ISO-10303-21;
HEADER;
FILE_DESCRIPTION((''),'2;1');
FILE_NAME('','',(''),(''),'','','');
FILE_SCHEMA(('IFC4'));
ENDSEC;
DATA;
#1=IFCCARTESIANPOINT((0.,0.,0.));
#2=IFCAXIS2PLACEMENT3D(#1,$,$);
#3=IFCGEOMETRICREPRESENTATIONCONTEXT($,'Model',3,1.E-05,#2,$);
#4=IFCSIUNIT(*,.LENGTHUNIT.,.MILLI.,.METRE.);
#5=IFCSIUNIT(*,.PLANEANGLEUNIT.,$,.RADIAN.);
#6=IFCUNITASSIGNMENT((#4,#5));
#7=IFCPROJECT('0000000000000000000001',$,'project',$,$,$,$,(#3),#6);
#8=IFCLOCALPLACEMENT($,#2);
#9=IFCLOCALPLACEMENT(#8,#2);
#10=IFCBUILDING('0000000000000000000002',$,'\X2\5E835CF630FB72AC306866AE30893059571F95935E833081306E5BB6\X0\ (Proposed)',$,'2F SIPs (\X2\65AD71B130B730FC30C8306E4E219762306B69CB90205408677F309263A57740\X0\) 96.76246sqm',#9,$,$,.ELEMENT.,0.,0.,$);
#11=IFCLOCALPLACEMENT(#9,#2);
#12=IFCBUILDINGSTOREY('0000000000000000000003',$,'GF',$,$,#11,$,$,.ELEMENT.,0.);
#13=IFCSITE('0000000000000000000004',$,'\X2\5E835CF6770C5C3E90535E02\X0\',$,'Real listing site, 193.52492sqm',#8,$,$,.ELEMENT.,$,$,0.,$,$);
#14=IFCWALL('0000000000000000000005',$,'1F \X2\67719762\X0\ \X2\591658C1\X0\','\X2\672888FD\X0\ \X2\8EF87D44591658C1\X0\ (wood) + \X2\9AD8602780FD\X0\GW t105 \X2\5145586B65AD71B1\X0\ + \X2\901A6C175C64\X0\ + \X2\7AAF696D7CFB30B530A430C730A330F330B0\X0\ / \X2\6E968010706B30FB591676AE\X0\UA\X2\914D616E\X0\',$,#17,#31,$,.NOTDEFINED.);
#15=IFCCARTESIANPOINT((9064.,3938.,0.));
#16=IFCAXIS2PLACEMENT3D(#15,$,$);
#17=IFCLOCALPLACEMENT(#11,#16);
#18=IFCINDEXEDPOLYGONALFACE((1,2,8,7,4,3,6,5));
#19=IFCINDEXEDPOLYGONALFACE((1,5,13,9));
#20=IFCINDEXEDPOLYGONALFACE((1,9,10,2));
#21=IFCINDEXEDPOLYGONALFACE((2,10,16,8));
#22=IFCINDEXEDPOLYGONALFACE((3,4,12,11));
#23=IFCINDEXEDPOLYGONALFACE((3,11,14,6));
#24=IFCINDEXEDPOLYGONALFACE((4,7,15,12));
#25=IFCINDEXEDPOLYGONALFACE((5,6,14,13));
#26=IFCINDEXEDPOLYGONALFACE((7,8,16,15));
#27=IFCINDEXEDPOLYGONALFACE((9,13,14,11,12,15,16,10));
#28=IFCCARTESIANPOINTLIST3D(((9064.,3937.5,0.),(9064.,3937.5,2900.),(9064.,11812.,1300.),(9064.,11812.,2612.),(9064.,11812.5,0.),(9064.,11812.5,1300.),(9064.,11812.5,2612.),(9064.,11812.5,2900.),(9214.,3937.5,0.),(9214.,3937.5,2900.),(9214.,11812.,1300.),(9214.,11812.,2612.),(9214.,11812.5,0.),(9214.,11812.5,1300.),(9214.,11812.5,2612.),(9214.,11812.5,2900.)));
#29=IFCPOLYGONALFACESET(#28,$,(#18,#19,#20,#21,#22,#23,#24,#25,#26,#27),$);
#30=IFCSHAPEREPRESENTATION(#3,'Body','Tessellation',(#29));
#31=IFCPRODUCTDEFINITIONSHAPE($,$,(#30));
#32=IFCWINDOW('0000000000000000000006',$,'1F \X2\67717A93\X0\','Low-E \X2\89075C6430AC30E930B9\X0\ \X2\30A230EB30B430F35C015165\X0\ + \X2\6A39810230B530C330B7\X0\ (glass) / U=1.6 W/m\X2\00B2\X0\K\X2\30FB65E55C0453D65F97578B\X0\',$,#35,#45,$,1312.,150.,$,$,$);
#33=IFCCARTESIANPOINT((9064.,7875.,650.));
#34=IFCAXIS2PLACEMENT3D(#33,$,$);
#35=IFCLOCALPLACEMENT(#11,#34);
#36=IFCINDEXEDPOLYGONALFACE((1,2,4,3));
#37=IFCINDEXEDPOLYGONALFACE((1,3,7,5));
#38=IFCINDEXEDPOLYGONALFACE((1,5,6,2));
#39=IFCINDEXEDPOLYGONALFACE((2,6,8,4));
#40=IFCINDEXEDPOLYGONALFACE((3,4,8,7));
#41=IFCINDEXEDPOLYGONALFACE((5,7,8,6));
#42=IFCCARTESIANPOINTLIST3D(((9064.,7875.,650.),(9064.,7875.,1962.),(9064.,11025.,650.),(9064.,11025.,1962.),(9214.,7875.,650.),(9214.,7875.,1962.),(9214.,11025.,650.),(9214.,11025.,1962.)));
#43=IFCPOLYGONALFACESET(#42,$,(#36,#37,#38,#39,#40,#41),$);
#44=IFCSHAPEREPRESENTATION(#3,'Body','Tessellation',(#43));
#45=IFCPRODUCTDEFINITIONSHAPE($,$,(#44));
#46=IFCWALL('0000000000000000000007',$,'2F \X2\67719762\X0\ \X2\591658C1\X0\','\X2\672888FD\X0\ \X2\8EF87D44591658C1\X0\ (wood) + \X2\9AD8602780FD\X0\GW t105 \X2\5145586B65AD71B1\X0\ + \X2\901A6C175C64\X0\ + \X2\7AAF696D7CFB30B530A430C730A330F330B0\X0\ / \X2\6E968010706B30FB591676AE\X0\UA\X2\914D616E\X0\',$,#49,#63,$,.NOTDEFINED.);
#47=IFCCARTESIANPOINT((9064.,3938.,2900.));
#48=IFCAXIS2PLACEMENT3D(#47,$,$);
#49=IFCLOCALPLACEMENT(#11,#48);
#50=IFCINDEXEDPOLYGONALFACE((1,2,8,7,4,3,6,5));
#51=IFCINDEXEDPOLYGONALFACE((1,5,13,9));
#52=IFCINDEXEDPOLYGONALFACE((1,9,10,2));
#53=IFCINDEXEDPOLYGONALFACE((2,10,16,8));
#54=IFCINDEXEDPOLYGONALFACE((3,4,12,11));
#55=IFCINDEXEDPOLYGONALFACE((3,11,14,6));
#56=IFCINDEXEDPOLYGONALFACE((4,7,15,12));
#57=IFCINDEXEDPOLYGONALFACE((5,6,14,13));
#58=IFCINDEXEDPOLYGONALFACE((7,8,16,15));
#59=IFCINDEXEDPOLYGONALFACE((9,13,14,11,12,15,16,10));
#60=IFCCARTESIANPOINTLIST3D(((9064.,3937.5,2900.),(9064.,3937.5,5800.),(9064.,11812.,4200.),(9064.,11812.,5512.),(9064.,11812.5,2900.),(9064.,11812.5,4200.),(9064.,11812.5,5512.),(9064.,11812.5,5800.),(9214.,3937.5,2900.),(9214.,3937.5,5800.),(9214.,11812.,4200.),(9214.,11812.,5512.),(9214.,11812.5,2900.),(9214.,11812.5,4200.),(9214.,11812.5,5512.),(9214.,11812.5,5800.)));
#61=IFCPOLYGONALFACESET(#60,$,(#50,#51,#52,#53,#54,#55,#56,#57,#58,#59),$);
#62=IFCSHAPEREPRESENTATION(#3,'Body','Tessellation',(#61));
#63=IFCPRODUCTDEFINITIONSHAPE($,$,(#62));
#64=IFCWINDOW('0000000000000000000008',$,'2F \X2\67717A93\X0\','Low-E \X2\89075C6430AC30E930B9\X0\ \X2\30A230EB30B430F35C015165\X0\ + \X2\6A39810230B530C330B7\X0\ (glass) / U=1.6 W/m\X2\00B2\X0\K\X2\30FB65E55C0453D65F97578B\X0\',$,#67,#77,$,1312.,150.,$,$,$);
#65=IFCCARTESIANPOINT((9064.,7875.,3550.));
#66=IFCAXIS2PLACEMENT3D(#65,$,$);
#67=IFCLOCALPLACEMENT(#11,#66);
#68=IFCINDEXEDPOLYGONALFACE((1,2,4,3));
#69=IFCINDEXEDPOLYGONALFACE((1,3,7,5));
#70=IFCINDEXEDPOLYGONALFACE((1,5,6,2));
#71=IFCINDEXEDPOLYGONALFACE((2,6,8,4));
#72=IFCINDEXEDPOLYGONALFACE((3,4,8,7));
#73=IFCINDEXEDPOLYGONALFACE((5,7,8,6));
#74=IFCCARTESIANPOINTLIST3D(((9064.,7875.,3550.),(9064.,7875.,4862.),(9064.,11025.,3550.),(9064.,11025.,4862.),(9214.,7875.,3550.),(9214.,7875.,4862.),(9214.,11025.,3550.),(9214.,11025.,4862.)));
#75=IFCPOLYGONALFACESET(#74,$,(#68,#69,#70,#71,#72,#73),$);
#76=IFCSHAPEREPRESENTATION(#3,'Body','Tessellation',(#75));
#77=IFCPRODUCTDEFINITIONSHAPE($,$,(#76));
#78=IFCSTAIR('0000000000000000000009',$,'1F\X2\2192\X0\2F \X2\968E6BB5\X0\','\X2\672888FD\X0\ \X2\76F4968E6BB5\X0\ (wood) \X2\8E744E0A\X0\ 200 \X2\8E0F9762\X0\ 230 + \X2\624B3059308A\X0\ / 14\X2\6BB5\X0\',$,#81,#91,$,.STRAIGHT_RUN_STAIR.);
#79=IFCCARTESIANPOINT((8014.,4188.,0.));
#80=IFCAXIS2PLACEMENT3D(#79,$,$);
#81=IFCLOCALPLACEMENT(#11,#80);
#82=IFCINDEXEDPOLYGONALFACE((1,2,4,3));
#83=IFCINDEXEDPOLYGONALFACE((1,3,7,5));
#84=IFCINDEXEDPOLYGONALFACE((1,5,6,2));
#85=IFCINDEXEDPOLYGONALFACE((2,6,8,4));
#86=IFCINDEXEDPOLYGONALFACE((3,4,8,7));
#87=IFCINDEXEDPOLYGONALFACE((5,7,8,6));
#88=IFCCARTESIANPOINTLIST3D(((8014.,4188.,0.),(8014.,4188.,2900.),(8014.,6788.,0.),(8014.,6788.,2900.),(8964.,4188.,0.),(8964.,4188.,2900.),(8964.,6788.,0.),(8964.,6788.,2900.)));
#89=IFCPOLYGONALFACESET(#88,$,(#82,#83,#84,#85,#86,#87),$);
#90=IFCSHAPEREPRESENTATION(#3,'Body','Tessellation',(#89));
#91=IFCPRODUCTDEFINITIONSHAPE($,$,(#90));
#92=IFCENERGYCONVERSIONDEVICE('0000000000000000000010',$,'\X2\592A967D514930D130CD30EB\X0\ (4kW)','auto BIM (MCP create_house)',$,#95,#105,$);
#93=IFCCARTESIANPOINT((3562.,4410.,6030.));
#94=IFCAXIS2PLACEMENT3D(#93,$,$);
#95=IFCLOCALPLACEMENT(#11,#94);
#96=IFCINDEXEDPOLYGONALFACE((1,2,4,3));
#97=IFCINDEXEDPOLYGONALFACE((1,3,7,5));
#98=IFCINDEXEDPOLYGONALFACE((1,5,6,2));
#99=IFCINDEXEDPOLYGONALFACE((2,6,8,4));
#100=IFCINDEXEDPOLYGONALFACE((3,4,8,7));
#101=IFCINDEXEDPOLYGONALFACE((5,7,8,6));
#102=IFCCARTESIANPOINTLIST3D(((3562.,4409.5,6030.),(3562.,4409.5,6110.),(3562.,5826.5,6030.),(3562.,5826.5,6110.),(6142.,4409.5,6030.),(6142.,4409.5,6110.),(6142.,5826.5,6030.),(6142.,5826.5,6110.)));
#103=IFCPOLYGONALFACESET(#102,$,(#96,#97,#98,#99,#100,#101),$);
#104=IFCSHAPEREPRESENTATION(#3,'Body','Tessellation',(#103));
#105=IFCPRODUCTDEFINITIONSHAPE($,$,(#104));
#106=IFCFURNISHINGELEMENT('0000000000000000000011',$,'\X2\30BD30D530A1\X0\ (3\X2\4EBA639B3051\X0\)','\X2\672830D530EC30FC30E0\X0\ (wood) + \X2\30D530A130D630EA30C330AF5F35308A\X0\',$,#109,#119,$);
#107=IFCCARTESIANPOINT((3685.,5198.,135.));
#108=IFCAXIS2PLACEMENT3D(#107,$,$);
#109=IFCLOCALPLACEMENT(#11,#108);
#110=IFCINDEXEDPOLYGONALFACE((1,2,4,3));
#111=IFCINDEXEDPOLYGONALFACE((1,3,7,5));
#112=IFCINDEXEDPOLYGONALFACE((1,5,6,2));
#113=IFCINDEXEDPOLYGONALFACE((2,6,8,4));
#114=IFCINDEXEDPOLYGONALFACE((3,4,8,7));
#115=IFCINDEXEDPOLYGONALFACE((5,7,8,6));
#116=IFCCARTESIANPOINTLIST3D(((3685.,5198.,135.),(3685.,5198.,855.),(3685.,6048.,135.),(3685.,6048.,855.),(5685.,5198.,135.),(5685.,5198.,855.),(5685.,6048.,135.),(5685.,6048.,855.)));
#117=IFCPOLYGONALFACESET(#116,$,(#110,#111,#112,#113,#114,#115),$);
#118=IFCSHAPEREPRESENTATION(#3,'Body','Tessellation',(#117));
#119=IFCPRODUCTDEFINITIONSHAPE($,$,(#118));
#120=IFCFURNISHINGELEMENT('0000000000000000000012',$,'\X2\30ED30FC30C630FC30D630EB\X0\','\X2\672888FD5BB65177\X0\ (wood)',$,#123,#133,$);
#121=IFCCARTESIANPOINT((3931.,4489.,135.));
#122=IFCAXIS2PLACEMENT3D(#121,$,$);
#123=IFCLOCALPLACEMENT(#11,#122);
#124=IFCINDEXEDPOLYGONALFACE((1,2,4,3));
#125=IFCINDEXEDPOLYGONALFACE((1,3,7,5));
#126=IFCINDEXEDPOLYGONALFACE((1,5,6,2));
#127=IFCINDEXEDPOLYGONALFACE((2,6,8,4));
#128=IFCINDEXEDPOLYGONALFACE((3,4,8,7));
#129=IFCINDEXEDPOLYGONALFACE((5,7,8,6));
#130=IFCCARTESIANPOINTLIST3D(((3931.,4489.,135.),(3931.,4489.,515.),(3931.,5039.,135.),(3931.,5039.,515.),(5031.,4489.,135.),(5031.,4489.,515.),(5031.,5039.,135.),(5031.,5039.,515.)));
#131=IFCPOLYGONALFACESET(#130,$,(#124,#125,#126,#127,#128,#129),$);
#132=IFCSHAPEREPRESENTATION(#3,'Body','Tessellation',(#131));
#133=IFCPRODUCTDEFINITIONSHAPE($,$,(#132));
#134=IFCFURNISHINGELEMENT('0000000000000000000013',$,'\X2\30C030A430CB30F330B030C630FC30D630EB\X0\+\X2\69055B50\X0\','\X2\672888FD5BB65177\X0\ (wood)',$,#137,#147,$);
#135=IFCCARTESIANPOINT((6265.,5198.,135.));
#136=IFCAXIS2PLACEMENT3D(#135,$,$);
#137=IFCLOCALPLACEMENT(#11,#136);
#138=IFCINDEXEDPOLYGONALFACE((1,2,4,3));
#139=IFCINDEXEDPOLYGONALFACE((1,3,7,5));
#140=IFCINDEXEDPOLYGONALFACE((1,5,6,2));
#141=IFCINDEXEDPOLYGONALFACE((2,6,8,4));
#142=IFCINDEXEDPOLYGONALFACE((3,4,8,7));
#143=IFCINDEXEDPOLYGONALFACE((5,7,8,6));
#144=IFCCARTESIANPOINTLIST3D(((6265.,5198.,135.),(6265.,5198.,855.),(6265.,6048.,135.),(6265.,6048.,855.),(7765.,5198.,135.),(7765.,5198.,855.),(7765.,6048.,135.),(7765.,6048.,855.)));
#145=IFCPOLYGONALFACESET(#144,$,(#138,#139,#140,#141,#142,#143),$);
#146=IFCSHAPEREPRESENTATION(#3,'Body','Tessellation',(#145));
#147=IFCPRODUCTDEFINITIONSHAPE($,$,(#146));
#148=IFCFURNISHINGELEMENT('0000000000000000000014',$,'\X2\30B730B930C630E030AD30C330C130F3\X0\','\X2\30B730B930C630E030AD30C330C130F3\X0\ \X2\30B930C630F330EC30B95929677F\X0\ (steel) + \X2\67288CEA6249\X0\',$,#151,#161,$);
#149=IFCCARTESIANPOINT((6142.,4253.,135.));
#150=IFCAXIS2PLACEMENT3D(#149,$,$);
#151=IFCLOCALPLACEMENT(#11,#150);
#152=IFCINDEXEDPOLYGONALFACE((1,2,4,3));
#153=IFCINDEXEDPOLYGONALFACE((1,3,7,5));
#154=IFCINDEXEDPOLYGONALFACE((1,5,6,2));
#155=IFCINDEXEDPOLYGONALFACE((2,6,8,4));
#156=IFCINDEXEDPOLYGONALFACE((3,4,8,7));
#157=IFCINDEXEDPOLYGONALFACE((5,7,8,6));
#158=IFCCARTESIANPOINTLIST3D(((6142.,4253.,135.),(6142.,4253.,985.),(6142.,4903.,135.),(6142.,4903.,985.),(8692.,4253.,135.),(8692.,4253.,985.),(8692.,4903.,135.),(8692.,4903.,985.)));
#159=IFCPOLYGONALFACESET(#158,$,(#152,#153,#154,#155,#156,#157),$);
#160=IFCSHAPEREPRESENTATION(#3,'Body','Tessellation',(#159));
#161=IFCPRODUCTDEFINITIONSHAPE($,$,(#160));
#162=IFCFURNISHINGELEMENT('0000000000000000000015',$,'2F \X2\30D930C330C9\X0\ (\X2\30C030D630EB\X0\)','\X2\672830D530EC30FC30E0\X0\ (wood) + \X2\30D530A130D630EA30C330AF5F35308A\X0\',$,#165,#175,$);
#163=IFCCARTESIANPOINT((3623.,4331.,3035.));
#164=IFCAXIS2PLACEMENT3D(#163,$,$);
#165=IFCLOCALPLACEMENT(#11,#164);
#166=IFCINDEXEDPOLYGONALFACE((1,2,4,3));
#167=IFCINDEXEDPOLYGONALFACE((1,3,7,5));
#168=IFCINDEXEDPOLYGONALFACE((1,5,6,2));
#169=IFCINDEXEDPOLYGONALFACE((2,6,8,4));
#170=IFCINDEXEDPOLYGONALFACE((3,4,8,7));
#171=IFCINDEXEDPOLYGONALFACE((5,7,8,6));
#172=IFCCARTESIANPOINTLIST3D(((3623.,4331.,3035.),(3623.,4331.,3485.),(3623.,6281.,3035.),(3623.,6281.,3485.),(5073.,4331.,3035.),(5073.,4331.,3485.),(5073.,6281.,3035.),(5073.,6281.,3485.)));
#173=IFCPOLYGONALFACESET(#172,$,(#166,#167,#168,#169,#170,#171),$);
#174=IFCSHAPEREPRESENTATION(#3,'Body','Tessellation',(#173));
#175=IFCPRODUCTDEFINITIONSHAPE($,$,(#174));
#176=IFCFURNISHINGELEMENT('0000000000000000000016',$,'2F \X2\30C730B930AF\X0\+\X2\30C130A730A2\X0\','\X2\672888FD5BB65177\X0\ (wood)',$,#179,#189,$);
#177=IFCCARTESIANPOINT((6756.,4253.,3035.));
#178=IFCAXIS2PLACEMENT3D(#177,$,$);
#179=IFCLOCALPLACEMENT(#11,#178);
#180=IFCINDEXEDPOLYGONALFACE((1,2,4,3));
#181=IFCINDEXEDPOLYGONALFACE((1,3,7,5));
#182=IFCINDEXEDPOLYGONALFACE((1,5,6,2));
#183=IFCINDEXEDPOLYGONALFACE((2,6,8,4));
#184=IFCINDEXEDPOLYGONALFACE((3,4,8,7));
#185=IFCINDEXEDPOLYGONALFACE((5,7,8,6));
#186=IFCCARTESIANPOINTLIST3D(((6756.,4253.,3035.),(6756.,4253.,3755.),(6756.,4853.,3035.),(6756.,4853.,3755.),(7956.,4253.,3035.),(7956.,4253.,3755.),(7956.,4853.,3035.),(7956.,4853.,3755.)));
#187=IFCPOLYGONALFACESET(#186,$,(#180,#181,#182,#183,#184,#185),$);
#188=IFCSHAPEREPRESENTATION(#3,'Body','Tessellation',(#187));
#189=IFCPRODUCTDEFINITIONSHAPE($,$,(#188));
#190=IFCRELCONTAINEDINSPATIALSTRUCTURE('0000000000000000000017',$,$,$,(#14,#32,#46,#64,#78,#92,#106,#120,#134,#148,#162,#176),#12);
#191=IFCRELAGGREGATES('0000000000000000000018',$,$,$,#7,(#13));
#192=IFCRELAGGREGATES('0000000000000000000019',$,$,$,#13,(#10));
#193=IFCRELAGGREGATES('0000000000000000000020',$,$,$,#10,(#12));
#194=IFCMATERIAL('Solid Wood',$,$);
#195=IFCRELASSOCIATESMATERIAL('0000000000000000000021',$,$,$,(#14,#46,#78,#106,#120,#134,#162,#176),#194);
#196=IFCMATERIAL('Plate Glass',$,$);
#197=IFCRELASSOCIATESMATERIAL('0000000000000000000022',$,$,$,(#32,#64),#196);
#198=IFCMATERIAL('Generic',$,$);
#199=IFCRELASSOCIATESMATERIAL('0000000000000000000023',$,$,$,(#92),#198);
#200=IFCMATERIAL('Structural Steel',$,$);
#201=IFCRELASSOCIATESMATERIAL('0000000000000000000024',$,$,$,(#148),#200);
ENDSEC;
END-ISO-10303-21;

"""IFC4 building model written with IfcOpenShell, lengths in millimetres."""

from ifc_helpers import new_model, si_unit, frame, frame_2d, origin, place, context, project, spatial, rectangle, extrude, material, element, fill, save


model = new_model("IFC4")

# Units and contexts
model_context = context("Model", 3, precision=1e-05, world=origin())
ifc_project = project(units=[si_unit("LENGTHUNIT", "METRE", prefix="MILLI"), si_unit("PLANEANGLEUNIT", "RADIAN")], contexts=[model_context])

# Site, building, storey
site_placement = place(None, origin())
site = spatial("IfcSite", under=ifc_project, at=site_placement, Name="広島県尾道市", ObjectType="Real listing site, 193.52492sqm", CompositionType="ELEMENT", RefElevation=0.0)
building_placement = place(site_placement, origin())
building = spatial("IfcBuilding", under=site, at=building_placement, Name="広島・犬と暮らす土間広めの家 (Proposed)", ObjectType="2F SIPs (断熱シートの両面に構造合板を接着) 96.76246sqm", CompositionType="ELEMENT", ElevationOfRefHeight=0.0, ElevationOfTerrain=0.0)
storey_placement = place(building_placement, origin())
storey = spatial("IfcBuildingStorey", under=building, at=storey_placement, Name="GF", CompositionType="ELEMENT", Elevation=0.0)

# Wall, opening, window
ifc_material_1 = material(Name="Solid Wood")
wall_1_placement = place(storey_placement, frame((9064.0, 3938.0, 0.0)))
wall_1 = element("IfcWall", 1, at=wall_1_placement, inside=storey, material=ifc_material_1, Name="1F 東面 外壁", Description="木製 軸組外壁 (wood) + 高性能GW t105 充填断熱 + 通気層 + 窯業系サイディング / 準耐火・外皮UA配慮", PredefinedType="NOTDEFINED", context=model_context, shape_type="SweptSolid", body=[
    extrude(rectangle(XDim=150.0, YDim=7875.0, at=frame_2d((75.0, 3937.0))), frame((9064.0, 3938.0, 0.0)), (0.0, 0.0, 1.0), 2900.0),
])
opening_1_placement = place(storey_placement, frame((9064.0, 7875.0, 650.0)))
opening_1 = element("IfcOpeningElement", 2, at=opening_1_placement, cuts=wall_1, PredefinedType="NOTDEFINED", context=model_context, shape_type="SweptSolid", body=[
    extrude(rectangle(XDim=150.0, YDim=3150.0, at=frame_2d((75.0, 1575.0))), frame((9064.0, 7875.0, 650.0)), (0.0, 0.0, 1.0), 1312.0),
])
ifc_material_2 = material(Name="Plate Glass")
window_1_placement = place(storey_placement, frame((9064.0, 7875.0, 650.0)))
window_1 = element("IfcWindow", 3, at=window_1_placement, inside=storey, material=ifc_material_2, Name="1F 東窓", Description="Low-E 複層ガラス アルゴン封入 + 樹脂サッシ (glass) / U=1.6 W/m²K・日射取得型", OverallHeight=1312.0, OverallWidth=150.0, context=model_context, shape_type="SweptSolid", body=[
    extrude(rectangle(XDim=150.0, YDim=3150.0, at=frame_2d((75.0, 1575.0))), frame((9064.0, 7875.0, 650.0)), (0.0, 0.0, 1.0), 1312.0),
])
fill(opening_1, window_1)

# Wall, opening, window
wall_2_placement = place(storey_placement, frame((9064.0, 3938.0, 2900.0)))
wall_2 = element("IfcWall", 4, at=wall_2_placement, inside=storey, material=ifc_material_1, Name="2F 東面 外壁", Description="木製 軸組外壁 (wood) + 高性能GW t105 充填断熱 + 通気層 + 窯業系サイディング / 準耐火・外皮UA配慮", PredefinedType="NOTDEFINED", context=model_context, shape_type="SweptSolid", body=[
    extrude(rectangle(XDim=150.0, YDim=7875.0, at=frame_2d((75.0, 3937.0))), frame((9064.0, 3938.0, 2900.0)), (0.0, 0.0, 1.0), 2900.0),
])
opening_2_placement = place(storey_placement, frame((9064.0, 7875.0, 3550.0)))
opening_2 = element("IfcOpeningElement", 5, at=opening_2_placement, cuts=wall_2, PredefinedType="NOTDEFINED", context=model_context, shape_type="SweptSolid", body=[
    extrude(rectangle(XDim=150.0, YDim=3150.0, at=frame_2d((75.0, 1575.0))), frame((9064.0, 7875.0, 3550.0)), (0.0, 0.0, 1.0), 1312.0),
])
window_2_placement = place(storey_placement, frame((9064.0, 7875.0, 3550.0)))
window_2 = element("IfcWindow", 6, at=window_2_placement, inside=storey, material=ifc_material_2, Name="2F 東窓", Description="Low-E 複層ガラス アルゴン封入 + 樹脂サッシ (glass) / U=1.6 W/m²K・日射取得型", OverallHeight=1312.0, OverallWidth=150.0, context=model_context, shape_type="SweptSolid", body=[
    extrude(rectangle(XDim=150.0, YDim=3150.0, at=frame_2d((75.0, 1575.0))), frame((9064.0, 7875.0, 3550.0)), (0.0, 0.0, 1.0), 1312.0),
])
fill(opening_2, window_2)

# Stair
stair_placement = place(storey_placement, frame((8014.0, 4188.0, 0.0)))
element("IfcStair", 7, at=stair_placement, inside=storey, material=ifc_material_1, Name="1F→2F 階段", Description="木製 直階段 (wood) 蹴上 200 踏面 230 + 手すり / 14段", PredefinedType="STRAIGHT_RUN_STAIR", context=model_context, shape_type="SweptSolid", body=[
    extrude(rectangle(XDim=950.0, YDim=2600.0, at=frame_2d((475.0, 1300.0))), frame((8014.0, 4188.0, 0.0)), (0.0, 0.0, 1.0), 2900.0),
])

# Energy conversion device
ifc_material_3 = material(Name="Generic")
energy_conversion_device_placement = place(storey_placement, frame((3562.0, 4410.0, 6030.0)))
element("IfcEnergyConversionDevice", 8, at=energy_conversion_device_placement, inside=storey, material=ifc_material_3, Name="太陽光パネル (4kW)", Description="auto BIM (MCP create_house)", context=model_context, shape_type="SweptSolid", body=[
    extrude(rectangle(XDim=2580.0, YDim=1417.0, at=frame_2d((1290.0, 708.0))), frame((3562.0, 4410.0, 6030.0)), (0.0, 0.0, 1.0), 80.0),
])

# Furnishing elements
furnishing_1_placement = place(storey_placement, frame((3685.0, 5198.0, 135.0)))
element("IfcFurnishingElement", 9, at=furnishing_1_placement, inside=storey, material=ifc_material_1, Name="ソファ (3人掛け)", Description="木フレーム (wood) + ファブリック張り", context=model_context, shape_type="SweptSolid", body=[
    extrude(rectangle(XDim=2000.0, YDim=850.0, at=frame_2d((1000.0, 425.0))), frame((3685.0, 5198.0, 135.0)), (0.0, 0.0, 1.0), 720.0),
])
furnishing_2_placement = place(storey_placement, frame((3931.0, 4489.0, 135.0)))
element("IfcFurnishingElement", 10, at=furnishing_2_placement, inside=storey, material=ifc_material_1, Name="ローテーブル", Description="木製家具 (wood)", context=model_context, shape_type="SweptSolid", body=[
    extrude(rectangle(XDim=1100.0, YDim=550.0, at=frame_2d((550.0, 275.0))), frame((3931.0, 4489.0, 135.0)), (0.0, 0.0, 1.0), 380.0),
])
furnishing_3_placement = place(storey_placement, frame((6265.0, 5198.0, 135.0)))
element("IfcFurnishingElement", 11, at=furnishing_3_placement, inside=storey, material=ifc_material_1, Name="ダイニングテーブル+椅子", Description="木製家具 (wood)", context=model_context, shape_type="SweptSolid", body=[
    extrude(rectangle(XDim=1500.0, YDim=850.0, at=frame_2d((750.0, 425.0))), frame((6265.0, 5198.0, 135.0)), (0.0, 0.0, 1.0), 720.0),
])
ifc_material_4 = material(Name="Structural Steel")
furnishing_4_placement = place(storey_placement, frame((6142.0, 4253.0, 135.0)))
element("IfcFurnishingElement", 12, at=furnishing_4_placement, inside=storey, material=ifc_material_4, Name="システムキッチン", Description="システムキッチン ステンレス天板 (steel) + 木質扉", context=model_context, shape_type="SweptSolid", body=[
    extrude(rectangle(XDim=2550.0, YDim=650.0, at=frame_2d((1275.0, 325.0))), frame((6142.0, 4253.0, 135.0)), (0.0, 0.0, 1.0), 850.0),
])
furnishing_5_placement = place(storey_placement, frame((3623.0, 4331.0, 3035.0)))
element("IfcFurnishingElement", 13, at=furnishing_5_placement, inside=storey, material=ifc_material_1, Name="2F ベッド (ダブル)", Description="木フレーム (wood) + ファブリック張り", context=model_context, shape_type="SweptSolid", body=[
    extrude(rectangle(XDim=1450.0, YDim=1950.0, at=frame_2d((725.0, 975.0))), frame((3623.0, 4331.0, 3035.0)), (0.0, 0.0, 1.0), 450.0),
])
furnishing_6_placement = place(storey_placement, frame((6756.0, 4253.0, 3035.0)))
element("IfcFurnishingElement", 14, at=furnishing_6_placement, inside=storey, material=ifc_material_1, Name="2F デスク+チェア", Description="木製家具 (wood)", context=model_context, shape_type="SweptSolid", body=[
    extrude(rectangle(XDim=1200.0, YDim=600.0, at=frame_2d((600.0, 300.0))), frame((6756.0, 4253.0, 3035.0)), (0.0, 0.0, 1.0), 720.0),
])

save(model, "model.ifc")
